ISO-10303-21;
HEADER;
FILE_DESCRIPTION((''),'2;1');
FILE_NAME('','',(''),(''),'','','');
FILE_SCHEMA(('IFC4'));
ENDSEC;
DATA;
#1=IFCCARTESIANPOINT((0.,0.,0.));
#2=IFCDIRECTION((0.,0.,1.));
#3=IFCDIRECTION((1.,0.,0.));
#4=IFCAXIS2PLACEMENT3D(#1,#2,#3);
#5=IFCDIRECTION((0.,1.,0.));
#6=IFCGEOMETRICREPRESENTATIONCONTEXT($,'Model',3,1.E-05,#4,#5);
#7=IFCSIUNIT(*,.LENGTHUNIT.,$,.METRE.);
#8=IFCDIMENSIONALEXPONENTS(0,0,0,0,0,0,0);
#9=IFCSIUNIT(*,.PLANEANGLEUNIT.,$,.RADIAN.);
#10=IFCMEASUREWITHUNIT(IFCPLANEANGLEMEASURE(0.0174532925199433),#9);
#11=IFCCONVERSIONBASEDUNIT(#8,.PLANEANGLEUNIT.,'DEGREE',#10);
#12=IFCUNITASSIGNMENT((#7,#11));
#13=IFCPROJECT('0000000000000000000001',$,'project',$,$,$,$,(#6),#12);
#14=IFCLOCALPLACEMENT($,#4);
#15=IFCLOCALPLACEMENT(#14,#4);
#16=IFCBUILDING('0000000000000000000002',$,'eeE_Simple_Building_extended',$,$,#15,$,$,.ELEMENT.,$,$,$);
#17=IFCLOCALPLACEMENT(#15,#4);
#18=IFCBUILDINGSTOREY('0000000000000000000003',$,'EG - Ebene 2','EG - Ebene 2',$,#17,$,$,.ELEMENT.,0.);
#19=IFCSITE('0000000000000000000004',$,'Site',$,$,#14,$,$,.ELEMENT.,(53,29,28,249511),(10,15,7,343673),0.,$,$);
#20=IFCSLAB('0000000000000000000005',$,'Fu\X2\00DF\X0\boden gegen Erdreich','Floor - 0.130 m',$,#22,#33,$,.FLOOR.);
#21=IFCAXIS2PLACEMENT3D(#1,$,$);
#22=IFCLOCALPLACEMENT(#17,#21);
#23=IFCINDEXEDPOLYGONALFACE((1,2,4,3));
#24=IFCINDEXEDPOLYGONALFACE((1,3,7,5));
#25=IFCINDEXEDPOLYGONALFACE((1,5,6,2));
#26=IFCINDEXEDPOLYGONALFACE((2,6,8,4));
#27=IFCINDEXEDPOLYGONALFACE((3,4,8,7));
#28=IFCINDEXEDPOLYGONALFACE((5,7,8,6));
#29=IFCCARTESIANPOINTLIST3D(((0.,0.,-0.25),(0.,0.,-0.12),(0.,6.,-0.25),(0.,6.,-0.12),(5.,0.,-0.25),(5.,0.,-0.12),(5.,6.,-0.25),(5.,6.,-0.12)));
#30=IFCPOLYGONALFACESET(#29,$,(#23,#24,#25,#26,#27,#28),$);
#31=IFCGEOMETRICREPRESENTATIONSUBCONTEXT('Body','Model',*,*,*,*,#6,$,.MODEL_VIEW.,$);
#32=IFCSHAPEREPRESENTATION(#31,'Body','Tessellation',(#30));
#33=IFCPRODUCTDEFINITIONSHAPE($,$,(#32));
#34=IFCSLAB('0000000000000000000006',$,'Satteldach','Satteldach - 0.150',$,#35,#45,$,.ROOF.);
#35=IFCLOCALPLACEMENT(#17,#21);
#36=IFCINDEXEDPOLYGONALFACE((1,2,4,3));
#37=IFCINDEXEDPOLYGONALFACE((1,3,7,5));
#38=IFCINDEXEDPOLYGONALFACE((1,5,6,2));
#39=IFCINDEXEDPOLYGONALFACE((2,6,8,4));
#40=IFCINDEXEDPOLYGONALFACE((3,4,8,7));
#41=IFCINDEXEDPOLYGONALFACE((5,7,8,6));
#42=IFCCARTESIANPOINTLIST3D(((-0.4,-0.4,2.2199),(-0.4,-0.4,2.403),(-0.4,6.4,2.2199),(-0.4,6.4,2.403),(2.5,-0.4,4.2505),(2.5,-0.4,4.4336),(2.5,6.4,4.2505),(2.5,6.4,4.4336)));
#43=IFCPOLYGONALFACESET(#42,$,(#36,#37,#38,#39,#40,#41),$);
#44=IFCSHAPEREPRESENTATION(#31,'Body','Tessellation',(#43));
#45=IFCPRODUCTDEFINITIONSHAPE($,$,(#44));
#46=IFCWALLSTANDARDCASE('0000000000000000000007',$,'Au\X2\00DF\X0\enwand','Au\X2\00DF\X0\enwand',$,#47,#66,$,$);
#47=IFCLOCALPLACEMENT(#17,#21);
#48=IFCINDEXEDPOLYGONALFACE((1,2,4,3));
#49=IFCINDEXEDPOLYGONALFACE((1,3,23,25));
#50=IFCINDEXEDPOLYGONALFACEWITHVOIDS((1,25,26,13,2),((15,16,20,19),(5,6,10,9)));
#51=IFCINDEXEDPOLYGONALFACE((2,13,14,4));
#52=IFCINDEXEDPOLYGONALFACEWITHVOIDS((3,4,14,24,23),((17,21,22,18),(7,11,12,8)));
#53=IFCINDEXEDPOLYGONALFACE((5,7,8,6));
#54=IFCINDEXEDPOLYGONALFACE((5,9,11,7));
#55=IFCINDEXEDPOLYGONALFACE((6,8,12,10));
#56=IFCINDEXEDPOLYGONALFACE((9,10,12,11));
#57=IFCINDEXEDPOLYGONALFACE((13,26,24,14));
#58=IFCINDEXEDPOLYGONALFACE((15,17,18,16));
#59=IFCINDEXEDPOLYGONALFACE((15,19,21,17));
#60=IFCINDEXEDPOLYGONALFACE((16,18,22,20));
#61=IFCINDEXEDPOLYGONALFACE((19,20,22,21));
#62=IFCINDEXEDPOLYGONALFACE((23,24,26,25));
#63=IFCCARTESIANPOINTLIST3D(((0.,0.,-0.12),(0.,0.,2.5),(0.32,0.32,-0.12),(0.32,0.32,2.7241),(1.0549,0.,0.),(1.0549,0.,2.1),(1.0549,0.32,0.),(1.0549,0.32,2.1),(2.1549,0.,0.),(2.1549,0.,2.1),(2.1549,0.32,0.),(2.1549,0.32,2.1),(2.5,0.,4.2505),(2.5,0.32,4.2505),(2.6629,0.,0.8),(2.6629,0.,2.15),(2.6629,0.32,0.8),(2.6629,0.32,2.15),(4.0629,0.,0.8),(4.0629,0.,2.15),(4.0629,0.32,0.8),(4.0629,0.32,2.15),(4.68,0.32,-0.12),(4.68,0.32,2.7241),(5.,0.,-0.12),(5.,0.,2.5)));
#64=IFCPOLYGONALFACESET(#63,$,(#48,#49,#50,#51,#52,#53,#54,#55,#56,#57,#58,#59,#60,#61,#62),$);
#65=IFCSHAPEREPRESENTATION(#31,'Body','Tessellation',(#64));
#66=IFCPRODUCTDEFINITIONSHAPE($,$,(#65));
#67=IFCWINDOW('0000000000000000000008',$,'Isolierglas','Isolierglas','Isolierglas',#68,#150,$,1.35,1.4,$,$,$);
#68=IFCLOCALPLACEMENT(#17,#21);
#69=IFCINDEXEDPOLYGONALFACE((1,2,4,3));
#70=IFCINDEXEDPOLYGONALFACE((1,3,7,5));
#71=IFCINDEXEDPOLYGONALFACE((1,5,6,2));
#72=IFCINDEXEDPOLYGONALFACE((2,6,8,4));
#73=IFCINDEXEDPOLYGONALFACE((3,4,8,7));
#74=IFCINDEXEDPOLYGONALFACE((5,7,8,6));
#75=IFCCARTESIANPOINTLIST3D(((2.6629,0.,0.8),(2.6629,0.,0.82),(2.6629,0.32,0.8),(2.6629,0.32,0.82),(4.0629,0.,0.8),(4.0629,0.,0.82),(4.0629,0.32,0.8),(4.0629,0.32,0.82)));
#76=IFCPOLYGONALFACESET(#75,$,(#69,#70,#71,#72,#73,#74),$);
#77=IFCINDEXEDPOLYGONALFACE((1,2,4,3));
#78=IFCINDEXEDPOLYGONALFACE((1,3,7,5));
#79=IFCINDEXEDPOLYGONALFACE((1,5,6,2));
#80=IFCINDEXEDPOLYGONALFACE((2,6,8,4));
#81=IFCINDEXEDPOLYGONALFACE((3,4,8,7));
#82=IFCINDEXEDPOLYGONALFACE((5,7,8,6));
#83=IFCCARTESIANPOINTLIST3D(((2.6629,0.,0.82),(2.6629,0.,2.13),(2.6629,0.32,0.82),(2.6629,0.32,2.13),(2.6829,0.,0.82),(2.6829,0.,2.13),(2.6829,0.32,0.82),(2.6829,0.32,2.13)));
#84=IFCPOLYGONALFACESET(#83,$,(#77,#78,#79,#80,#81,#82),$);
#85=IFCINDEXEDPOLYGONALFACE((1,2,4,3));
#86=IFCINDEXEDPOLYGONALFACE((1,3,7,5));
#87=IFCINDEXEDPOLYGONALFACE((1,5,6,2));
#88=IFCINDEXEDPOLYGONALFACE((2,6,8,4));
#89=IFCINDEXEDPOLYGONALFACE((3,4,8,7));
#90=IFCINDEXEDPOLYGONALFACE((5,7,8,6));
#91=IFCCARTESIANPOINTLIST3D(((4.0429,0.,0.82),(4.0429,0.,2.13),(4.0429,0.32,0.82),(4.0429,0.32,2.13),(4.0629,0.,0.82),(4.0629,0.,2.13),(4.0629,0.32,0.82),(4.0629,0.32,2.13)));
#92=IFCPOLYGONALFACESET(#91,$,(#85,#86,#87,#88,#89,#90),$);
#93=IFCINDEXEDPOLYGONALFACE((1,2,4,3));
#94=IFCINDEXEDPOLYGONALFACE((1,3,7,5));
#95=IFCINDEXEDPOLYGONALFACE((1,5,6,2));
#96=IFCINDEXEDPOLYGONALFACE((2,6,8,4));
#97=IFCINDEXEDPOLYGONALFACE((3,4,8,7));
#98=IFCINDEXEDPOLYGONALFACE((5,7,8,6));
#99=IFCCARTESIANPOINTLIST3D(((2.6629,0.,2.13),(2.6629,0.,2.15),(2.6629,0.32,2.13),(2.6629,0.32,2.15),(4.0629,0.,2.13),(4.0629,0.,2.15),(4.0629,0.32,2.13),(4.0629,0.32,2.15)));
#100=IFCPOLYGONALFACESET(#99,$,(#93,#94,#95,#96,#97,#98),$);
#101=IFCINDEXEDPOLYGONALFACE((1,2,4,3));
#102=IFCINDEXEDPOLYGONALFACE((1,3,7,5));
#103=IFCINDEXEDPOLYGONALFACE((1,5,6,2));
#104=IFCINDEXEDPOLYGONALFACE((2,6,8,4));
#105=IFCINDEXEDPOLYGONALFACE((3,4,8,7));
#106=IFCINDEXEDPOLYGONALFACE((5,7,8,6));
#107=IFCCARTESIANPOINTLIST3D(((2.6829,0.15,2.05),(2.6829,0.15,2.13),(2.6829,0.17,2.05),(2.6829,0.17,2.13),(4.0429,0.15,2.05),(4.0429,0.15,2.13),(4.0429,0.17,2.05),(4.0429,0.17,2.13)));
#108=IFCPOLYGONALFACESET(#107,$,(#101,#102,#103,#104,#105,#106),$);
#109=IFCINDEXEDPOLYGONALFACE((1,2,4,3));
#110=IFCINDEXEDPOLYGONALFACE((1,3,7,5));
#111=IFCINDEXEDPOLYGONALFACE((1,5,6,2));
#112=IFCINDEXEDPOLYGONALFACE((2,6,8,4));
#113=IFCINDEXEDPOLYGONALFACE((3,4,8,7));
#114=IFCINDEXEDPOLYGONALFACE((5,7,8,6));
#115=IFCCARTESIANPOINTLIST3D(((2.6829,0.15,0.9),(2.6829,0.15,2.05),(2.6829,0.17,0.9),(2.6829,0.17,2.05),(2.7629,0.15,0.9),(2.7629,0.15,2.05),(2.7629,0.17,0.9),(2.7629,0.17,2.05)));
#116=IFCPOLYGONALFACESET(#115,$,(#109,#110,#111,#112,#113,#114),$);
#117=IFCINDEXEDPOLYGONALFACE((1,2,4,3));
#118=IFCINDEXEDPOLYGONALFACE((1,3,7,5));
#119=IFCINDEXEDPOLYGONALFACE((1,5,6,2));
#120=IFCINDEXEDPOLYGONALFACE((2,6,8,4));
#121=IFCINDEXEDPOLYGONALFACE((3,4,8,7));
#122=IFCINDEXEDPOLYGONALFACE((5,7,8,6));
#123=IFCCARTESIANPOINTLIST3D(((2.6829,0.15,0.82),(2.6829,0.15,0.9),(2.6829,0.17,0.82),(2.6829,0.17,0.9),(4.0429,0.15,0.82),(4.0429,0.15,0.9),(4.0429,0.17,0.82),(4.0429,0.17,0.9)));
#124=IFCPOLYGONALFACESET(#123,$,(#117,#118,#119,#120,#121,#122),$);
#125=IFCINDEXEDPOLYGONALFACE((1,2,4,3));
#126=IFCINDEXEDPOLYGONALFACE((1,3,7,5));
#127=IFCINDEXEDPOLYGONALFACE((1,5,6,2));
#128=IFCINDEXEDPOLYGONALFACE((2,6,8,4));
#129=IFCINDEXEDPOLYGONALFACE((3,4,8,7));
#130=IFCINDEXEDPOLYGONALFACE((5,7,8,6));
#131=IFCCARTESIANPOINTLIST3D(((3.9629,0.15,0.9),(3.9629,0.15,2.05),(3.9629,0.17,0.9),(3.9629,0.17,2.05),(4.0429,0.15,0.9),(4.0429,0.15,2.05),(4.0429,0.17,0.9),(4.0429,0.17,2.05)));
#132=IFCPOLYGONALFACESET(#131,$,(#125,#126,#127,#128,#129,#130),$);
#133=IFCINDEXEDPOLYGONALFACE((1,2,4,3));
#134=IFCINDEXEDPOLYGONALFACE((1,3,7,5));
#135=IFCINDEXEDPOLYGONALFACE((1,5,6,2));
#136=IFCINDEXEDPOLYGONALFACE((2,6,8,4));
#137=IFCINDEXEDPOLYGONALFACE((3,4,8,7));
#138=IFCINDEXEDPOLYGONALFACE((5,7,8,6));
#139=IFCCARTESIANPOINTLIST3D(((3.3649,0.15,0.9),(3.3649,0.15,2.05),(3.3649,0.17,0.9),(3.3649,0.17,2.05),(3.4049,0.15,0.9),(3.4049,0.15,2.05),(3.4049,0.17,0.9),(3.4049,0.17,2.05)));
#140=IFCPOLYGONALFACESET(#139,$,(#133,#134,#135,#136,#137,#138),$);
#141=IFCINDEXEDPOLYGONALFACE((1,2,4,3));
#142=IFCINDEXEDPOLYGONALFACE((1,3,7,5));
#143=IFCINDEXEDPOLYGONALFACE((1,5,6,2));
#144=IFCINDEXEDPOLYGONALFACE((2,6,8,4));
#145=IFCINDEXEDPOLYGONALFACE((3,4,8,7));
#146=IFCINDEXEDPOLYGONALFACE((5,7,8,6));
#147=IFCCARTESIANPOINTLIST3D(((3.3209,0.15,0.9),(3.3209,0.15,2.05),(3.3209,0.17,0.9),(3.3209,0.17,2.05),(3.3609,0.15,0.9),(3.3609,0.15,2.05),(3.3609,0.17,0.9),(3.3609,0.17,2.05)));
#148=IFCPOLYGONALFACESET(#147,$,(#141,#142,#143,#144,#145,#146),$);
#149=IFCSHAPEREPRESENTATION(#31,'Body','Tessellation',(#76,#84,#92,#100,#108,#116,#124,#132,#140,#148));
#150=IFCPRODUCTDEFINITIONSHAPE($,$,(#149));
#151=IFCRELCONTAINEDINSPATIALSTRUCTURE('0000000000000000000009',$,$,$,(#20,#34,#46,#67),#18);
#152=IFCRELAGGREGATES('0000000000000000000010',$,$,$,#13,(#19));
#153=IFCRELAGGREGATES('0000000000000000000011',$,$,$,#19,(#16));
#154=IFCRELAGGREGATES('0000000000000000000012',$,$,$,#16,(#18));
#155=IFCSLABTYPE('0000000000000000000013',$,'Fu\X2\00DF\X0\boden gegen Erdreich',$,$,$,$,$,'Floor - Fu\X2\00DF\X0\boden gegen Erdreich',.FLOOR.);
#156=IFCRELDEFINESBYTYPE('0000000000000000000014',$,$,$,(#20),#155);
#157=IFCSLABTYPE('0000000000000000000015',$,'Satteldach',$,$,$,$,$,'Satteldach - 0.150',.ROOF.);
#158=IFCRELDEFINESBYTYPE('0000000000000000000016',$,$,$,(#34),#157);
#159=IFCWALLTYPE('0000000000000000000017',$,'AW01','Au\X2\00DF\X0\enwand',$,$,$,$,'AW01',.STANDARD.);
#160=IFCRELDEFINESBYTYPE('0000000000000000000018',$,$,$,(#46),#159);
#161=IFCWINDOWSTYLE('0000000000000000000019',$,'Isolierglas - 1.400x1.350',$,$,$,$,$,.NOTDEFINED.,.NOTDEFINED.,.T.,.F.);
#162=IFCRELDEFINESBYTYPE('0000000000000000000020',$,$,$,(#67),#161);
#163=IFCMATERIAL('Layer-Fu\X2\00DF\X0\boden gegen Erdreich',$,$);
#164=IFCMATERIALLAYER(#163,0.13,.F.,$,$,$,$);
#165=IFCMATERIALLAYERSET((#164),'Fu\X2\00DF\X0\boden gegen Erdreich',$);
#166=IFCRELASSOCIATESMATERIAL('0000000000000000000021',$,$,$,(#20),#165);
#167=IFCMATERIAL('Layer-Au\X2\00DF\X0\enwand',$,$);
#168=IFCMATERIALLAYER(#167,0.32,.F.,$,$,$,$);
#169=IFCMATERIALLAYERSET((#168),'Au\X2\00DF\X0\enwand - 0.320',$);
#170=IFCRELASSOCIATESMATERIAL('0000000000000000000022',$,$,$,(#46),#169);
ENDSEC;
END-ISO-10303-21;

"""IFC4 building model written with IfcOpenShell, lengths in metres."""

from ifc_helpers import new_model, entity, si_unit, converted_unit, direction, frame, origin_with_axes, origin_2d_with_axis, place, context, subcontext, project, spatial, polyline, rectangle, outline, extrude, clip, bounded_halfspace, source, transform, mapped, material, layer, layer_set, layer_usage, type_object, element, fill, save


model = new_model("IFC4")

# Units and contexts
model_context = context("Model", 3, precision=1e-05, world=origin_with_axes(), true_north=direction((0.0, 1.0, 0.0)))
body_context = subcontext(model_context, "Body", "Model", "MODEL_VIEW")
ifc_project = project(units=[si_unit("LENGTHUNIT", "METRE"), converted_unit("PLANEANGLEUNIT", "DEGREE", entity("IfcPlaneAngleMeasure", 0.0174532925199433), si_unit("PLANEANGLEUNIT", "RADIAN"), dimensions=[0, 0, 0, 0, 0, 0, 0])], contexts=[model_context])

# Site, building, storey
site_placement = place(None, origin_with_axes())
site = spatial("IfcSite", under=ifc_project, at=site_placement, Name="Site", CompositionType="ELEMENT", RefLatitude=(53, 29, 28, 249511), RefLongitude=(10, 15, 7, 343673), RefElevation=0.0)
building_placement = place(site_placement, origin_with_axes())
building = spatial("IfcBuilding", under=site, at=building_placement, Name="eeE_Simple_Building_extended", CompositionType="ELEMENT")
storey_placement = place(building_placement, origin_with_axes())
storey = spatial("IfcBuildingStorey", under=building, at=storey_placement, Name="EG - Ebene 2", Description="EG - Ebene 2", CompositionType="ELEMENT", Elevation=0.0)

# Slabs
ifc_material_1 = material(Name="Layer-Fußboden gegen Erdreich")
ifc_layer_1 = layer(ifc_material_1, 0.13, ventilated=False)
ifc_layer_set_1 = layer_set([ifc_layer_1], Name="Fußboden gegen Erdreich")
ifc_layer_usage_1 = layer_usage(ifc_layer_set_1, "AXIS2", "POSITIVE", 0.0)
slab_type_1 = type_object("IfcSlabType", Name="Fußboden gegen Erdreich", ElementType="Floor - Fußboden gegen Erdreich", PredefinedType="FLOOR")
slab_1_placement = place(storey_placement, frame((0.0, 0.0, -0.12), z_axis=(0.0, 0.0, 1.0), x_axis=(1.0, 0.0, 0.0)))
element("IfcSlab", 1, at=slab_1_placement, inside=storey, type_object=slab_type_1, material=ifc_layer_usage_1, Name="Fußboden gegen Erdreich", Description="Floor - 0.130 m", PredefinedType="FLOOR", context=body_context, shape_type="SweptSolid", body=[
    extrude(outline(polyline([(0.0, 0.0), (5.0, 0.0), (5.0, 6.0), (0.0, 6.0), (0.0, 0.0)])), origin_with_axes(), (0.0, 0.0, -1.0), 0.13),
])
slab_type_2 = type_object("IfcSlabType", Name="Satteldach", ElementType="Satteldach - 0.150", PredefinedType="ROOF")
slab_2_placement = place(storey_placement, frame((2.5, -0.4, 4.2505), z_axis=(-0.573576, 0.0, 0.819152), x_axis=(0.0, 1.0, 0.0)))
element("IfcSlab", 2, at=slab_2_placement, inside=storey, type_object=slab_type_2, Name="Satteldach", Description="Satteldach - 0.150", PredefinedType="ROOF", context=body_context, shape_type="SweptSolid", body=[
    extrude(outline(polyline([(0.0, 0.0), (6.8, 0.0), (6.8, 3.5402), (0.0, 3.5402), (0.0, 0.0)])), frame((0.0, 3.5402, 0.0), z_axis=(0.0, 0.0, -1.0), x_axis=(1.0, 0.0, 0.0)), (0.0, 0.573576, -0.819152), 0.1831),
])

# Wall, openings, window
ifc_material_2 = material(Name="Layer-Außenwand")
ifc_layer_2 = layer(ifc_material_2, 0.32, ventilated=False)
ifc_layer_set_2 = layer_set([ifc_layer_2], Name="Außenwand - 0.320")
ifc_layer_usage_2 = layer_usage(ifc_layer_set_2, "AXIS2", "POSITIVE", 0.0)
wall_type = type_object("IfcWallType", Name="AW01", Description="Außenwand", ElementType="AW01", PredefinedType="STANDARD")
wall_1_placement = place(storey_placement, frame((0.32, 0.32, -0.12), z_axis=(0.0, 0.0, 1.0), x_axis=(1.0, 0.0, 0.0)))
wall_1 = element("IfcWallStandardCase", 3, at=wall_1_placement, inside=storey, type_object=wall_type, material=ifc_layer_usage_2, Name="Außenwand", Description="Außenwand", context=body_context, shape_type="Clipping", body=[
    clip(clip(extrude(outline(polyline([(0.0, 0.0), (4.36, 0.0), (4.68, 0.32), (-0.32, 0.32), (0.0, 0.0)])), frame((0.0, 0.0, 0.0), z_axis=(0.0, 0.0, -1.0), x_axis=(1.0, 0.0, 0.0)), (0.0, 0.0, -1.0), 4.3705), bounded_halfspace(frame((2.18, 6.08, 4.3705), z_axis=(-0.573576, 0.0, -0.819152), x_axis=(0.0, 1.0, 0.0)), True, frame((2.18, 6.08, 0.12), z_axis=(0.0, 0.0, 1.0), x_axis=(0.0, -1.0, 0.0)), polyline([(0.0, 0.0), (6.8, 0.0), (6.8, 2.9), (0.0, 2.9), (0.0, 0.0)]))), bounded_halfspace(frame((2.18, -0.72, 4.3705), z_axis=(0.573576, 0.0, -0.819152), x_axis=(0.0, -1.0, 0.0)), True, frame((2.18, -0.72, 0.12), z_axis=(0.0, 0.0, 1.0), x_axis=(0.0, 1.0, 0.0)), polyline([(0.0, 0.0), (6.8, 0.0), (6.8, 2.9), (0.0, 2.9), (0.0, 0.0)]))),
])
opening_1_placement = place(wall_1_placement, frame((2.3429, 0.1, 0.92), z_axis=(0.0, 0.0, 1.0), x_axis=(1.0, 0.0, 0.0)))
opening_1 = element("IfcOpeningElement", 4, at=opening_1_placement, cuts=wall_1, context=body_context, shape_type="SweptSolid", body=[
    extrude(outline(polyline([(0.0, 0.0), (1.35, 0.0), (1.35, 1.4), (0.0, 1.4), (0.0, 0.0), (0.0, 0.0)])), frame((0.0, 0.0, 0.0), z_axis=(0.0, 1.0, 0.0), x_axis=(0.0, 0.0, 1.0)), (0.0, 0.0, -1.0), 0.52),
])
opening_2_placement = place(wall_1_placement, frame((1.8349, -0.42, 0.12), z_axis=(0.0, 0.0, 1.0), x_axis=(1.0, 0.0, 0.0)))
element("IfcOpeningElement", 5, at=opening_2_placement, cuts=wall_1, context=body_context, shape_type="SweptSolid", body=[
    extrude(outline(polyline([(0.0, 0.0), (1.1, 0.0), (1.1, 2.1), (0.0, 2.1), (0.0, 0.0), (0.0, 0.0)])), frame((0.0, 0.0, 0.0), z_axis=(0.0, 1.0, 0.0), x_axis=(-1.0, 0.0, 0.0)), (0.0, 0.0, 1.0), 0.52),
])
window_style = type_object("IfcWindowStyle", Name="Isolierglas - 1.400x1.350", ConstructionType="NOTDEFINED", OperationType="NOTDEFINED", ParameterTakesPrecedence=True, Sizeable=False)
shared_shape_1 = source(origin_with_axes(), body_context, "Body", "SweptSolid", [
    extrude(rectangle(XDim=1.4, YDim=0.32, at=origin_2d_with_axis()), frame((0.7, 0.16, 0.0), z_axis=(0.0, 0.0, 1.0), x_axis=(1.0, 0.0, 0.0)), (0.0, 0.0, 1.0), 0.02),
    extrude(rectangle(XDim=0.02, YDim=0.32, at=origin_2d_with_axis()), frame((0.01, 0.16, 0.02), z_axis=(0.0, 0.0, 1.0), x_axis=(1.0, 0.0, 0.0)), (0.0, 0.0, 1.0), 1.31),
    extrude(rectangle(XDim=0.02, YDim=0.32, at=origin_2d_with_axis()), frame((1.39, 0.16, 0.02), z_axis=(0.0, 0.0, 1.0), x_axis=(1.0, 0.0, 0.0)), (0.0, 0.0, 1.0), 1.31),
    extrude(rectangle(XDim=1.4, YDim=0.32, at=origin_2d_with_axis()), frame((0.7, 0.16, 1.33), z_axis=(0.0, 0.0, 1.0), x_axis=(1.0, 0.0, 0.0)), (0.0, 0.0, 1.0), 0.02),
    extrude(rectangle(XDim=1.36, YDim=0.02, at=origin_2d_with_axis()), frame((0.7, 0.16, 1.25), z_axis=(0.0, 0.0, 1.0), x_axis=(1.0, 0.0, 0.0)), (0.0, 0.0, 1.0), 0.08),
    extrude(rectangle(XDim=0.08, YDim=0.02, at=origin_2d_with_axis()), frame((0.06, 0.16, 0.1), z_axis=(0.0, 0.0, 1.0), x_axis=(1.0, 0.0, 0.0)), (0.0, 0.0, 1.0), 1.15),
    extrude(rectangle(XDim=1.36, YDim=0.02, at=origin_2d_with_axis()), frame((0.7, 0.16, 0.02), z_axis=(0.0, 0.0, 1.0), x_axis=(1.0, 0.0, 0.0)), (0.0, 0.0, 1.0), 0.08),
    extrude(rectangle(XDim=0.08, YDim=0.02, at=origin_2d_with_axis()), frame((1.34, 0.16, 0.1), z_axis=(0.0, 0.0, 1.0), x_axis=(1.0, 0.0, 0.0)), (0.0, 0.0, 1.0), 1.15),
    extrude(rectangle(XDim=0.04, YDim=0.02, at=origin_2d_with_axis()), frame((0.722, 0.16, 0.1), z_axis=(0.0, 0.0, 1.0), x_axis=(1.0, 0.0, 0.0)), (0.0, 0.0, 1.0), 1.15),
    extrude(rectangle(XDim=0.04, YDim=0.02, at=origin_2d_with_axis()), frame((0.678, 0.16, 0.1), z_axis=(0.0, 0.0, 1.0), x_axis=(1.0, 0.0, 0.0)), (0.0, 0.0, 1.0), 1.15),
])
window_placement = place(opening_1_placement, frame((0.0, -0.42, 0.0), z_axis=(0.0, 0.0, 1.0), x_axis=(1.0, 0.0, 0.0)))
window = element("IfcWindow", 6, at=window_placement, inside=storey, type_object=window_style, Name="Isolierglas", Description="Isolierglas", ObjectType="Isolierglas", OverallHeight=1.35, OverallWidth=1.4, context=body_context, shape_type="MappedRepresentation", body=[
    mapped(shared_shape_1, transform((0.0, 0.0, 0.0), x_axis=(1.0, 0.0, 0.0), y_axis=(0.0, 1.0, 0.0), z_axis=(0.0, 0.0, 1.0), scale=1.0)),
])
fill(opening_1, window)

save(model, "model.ifc")
